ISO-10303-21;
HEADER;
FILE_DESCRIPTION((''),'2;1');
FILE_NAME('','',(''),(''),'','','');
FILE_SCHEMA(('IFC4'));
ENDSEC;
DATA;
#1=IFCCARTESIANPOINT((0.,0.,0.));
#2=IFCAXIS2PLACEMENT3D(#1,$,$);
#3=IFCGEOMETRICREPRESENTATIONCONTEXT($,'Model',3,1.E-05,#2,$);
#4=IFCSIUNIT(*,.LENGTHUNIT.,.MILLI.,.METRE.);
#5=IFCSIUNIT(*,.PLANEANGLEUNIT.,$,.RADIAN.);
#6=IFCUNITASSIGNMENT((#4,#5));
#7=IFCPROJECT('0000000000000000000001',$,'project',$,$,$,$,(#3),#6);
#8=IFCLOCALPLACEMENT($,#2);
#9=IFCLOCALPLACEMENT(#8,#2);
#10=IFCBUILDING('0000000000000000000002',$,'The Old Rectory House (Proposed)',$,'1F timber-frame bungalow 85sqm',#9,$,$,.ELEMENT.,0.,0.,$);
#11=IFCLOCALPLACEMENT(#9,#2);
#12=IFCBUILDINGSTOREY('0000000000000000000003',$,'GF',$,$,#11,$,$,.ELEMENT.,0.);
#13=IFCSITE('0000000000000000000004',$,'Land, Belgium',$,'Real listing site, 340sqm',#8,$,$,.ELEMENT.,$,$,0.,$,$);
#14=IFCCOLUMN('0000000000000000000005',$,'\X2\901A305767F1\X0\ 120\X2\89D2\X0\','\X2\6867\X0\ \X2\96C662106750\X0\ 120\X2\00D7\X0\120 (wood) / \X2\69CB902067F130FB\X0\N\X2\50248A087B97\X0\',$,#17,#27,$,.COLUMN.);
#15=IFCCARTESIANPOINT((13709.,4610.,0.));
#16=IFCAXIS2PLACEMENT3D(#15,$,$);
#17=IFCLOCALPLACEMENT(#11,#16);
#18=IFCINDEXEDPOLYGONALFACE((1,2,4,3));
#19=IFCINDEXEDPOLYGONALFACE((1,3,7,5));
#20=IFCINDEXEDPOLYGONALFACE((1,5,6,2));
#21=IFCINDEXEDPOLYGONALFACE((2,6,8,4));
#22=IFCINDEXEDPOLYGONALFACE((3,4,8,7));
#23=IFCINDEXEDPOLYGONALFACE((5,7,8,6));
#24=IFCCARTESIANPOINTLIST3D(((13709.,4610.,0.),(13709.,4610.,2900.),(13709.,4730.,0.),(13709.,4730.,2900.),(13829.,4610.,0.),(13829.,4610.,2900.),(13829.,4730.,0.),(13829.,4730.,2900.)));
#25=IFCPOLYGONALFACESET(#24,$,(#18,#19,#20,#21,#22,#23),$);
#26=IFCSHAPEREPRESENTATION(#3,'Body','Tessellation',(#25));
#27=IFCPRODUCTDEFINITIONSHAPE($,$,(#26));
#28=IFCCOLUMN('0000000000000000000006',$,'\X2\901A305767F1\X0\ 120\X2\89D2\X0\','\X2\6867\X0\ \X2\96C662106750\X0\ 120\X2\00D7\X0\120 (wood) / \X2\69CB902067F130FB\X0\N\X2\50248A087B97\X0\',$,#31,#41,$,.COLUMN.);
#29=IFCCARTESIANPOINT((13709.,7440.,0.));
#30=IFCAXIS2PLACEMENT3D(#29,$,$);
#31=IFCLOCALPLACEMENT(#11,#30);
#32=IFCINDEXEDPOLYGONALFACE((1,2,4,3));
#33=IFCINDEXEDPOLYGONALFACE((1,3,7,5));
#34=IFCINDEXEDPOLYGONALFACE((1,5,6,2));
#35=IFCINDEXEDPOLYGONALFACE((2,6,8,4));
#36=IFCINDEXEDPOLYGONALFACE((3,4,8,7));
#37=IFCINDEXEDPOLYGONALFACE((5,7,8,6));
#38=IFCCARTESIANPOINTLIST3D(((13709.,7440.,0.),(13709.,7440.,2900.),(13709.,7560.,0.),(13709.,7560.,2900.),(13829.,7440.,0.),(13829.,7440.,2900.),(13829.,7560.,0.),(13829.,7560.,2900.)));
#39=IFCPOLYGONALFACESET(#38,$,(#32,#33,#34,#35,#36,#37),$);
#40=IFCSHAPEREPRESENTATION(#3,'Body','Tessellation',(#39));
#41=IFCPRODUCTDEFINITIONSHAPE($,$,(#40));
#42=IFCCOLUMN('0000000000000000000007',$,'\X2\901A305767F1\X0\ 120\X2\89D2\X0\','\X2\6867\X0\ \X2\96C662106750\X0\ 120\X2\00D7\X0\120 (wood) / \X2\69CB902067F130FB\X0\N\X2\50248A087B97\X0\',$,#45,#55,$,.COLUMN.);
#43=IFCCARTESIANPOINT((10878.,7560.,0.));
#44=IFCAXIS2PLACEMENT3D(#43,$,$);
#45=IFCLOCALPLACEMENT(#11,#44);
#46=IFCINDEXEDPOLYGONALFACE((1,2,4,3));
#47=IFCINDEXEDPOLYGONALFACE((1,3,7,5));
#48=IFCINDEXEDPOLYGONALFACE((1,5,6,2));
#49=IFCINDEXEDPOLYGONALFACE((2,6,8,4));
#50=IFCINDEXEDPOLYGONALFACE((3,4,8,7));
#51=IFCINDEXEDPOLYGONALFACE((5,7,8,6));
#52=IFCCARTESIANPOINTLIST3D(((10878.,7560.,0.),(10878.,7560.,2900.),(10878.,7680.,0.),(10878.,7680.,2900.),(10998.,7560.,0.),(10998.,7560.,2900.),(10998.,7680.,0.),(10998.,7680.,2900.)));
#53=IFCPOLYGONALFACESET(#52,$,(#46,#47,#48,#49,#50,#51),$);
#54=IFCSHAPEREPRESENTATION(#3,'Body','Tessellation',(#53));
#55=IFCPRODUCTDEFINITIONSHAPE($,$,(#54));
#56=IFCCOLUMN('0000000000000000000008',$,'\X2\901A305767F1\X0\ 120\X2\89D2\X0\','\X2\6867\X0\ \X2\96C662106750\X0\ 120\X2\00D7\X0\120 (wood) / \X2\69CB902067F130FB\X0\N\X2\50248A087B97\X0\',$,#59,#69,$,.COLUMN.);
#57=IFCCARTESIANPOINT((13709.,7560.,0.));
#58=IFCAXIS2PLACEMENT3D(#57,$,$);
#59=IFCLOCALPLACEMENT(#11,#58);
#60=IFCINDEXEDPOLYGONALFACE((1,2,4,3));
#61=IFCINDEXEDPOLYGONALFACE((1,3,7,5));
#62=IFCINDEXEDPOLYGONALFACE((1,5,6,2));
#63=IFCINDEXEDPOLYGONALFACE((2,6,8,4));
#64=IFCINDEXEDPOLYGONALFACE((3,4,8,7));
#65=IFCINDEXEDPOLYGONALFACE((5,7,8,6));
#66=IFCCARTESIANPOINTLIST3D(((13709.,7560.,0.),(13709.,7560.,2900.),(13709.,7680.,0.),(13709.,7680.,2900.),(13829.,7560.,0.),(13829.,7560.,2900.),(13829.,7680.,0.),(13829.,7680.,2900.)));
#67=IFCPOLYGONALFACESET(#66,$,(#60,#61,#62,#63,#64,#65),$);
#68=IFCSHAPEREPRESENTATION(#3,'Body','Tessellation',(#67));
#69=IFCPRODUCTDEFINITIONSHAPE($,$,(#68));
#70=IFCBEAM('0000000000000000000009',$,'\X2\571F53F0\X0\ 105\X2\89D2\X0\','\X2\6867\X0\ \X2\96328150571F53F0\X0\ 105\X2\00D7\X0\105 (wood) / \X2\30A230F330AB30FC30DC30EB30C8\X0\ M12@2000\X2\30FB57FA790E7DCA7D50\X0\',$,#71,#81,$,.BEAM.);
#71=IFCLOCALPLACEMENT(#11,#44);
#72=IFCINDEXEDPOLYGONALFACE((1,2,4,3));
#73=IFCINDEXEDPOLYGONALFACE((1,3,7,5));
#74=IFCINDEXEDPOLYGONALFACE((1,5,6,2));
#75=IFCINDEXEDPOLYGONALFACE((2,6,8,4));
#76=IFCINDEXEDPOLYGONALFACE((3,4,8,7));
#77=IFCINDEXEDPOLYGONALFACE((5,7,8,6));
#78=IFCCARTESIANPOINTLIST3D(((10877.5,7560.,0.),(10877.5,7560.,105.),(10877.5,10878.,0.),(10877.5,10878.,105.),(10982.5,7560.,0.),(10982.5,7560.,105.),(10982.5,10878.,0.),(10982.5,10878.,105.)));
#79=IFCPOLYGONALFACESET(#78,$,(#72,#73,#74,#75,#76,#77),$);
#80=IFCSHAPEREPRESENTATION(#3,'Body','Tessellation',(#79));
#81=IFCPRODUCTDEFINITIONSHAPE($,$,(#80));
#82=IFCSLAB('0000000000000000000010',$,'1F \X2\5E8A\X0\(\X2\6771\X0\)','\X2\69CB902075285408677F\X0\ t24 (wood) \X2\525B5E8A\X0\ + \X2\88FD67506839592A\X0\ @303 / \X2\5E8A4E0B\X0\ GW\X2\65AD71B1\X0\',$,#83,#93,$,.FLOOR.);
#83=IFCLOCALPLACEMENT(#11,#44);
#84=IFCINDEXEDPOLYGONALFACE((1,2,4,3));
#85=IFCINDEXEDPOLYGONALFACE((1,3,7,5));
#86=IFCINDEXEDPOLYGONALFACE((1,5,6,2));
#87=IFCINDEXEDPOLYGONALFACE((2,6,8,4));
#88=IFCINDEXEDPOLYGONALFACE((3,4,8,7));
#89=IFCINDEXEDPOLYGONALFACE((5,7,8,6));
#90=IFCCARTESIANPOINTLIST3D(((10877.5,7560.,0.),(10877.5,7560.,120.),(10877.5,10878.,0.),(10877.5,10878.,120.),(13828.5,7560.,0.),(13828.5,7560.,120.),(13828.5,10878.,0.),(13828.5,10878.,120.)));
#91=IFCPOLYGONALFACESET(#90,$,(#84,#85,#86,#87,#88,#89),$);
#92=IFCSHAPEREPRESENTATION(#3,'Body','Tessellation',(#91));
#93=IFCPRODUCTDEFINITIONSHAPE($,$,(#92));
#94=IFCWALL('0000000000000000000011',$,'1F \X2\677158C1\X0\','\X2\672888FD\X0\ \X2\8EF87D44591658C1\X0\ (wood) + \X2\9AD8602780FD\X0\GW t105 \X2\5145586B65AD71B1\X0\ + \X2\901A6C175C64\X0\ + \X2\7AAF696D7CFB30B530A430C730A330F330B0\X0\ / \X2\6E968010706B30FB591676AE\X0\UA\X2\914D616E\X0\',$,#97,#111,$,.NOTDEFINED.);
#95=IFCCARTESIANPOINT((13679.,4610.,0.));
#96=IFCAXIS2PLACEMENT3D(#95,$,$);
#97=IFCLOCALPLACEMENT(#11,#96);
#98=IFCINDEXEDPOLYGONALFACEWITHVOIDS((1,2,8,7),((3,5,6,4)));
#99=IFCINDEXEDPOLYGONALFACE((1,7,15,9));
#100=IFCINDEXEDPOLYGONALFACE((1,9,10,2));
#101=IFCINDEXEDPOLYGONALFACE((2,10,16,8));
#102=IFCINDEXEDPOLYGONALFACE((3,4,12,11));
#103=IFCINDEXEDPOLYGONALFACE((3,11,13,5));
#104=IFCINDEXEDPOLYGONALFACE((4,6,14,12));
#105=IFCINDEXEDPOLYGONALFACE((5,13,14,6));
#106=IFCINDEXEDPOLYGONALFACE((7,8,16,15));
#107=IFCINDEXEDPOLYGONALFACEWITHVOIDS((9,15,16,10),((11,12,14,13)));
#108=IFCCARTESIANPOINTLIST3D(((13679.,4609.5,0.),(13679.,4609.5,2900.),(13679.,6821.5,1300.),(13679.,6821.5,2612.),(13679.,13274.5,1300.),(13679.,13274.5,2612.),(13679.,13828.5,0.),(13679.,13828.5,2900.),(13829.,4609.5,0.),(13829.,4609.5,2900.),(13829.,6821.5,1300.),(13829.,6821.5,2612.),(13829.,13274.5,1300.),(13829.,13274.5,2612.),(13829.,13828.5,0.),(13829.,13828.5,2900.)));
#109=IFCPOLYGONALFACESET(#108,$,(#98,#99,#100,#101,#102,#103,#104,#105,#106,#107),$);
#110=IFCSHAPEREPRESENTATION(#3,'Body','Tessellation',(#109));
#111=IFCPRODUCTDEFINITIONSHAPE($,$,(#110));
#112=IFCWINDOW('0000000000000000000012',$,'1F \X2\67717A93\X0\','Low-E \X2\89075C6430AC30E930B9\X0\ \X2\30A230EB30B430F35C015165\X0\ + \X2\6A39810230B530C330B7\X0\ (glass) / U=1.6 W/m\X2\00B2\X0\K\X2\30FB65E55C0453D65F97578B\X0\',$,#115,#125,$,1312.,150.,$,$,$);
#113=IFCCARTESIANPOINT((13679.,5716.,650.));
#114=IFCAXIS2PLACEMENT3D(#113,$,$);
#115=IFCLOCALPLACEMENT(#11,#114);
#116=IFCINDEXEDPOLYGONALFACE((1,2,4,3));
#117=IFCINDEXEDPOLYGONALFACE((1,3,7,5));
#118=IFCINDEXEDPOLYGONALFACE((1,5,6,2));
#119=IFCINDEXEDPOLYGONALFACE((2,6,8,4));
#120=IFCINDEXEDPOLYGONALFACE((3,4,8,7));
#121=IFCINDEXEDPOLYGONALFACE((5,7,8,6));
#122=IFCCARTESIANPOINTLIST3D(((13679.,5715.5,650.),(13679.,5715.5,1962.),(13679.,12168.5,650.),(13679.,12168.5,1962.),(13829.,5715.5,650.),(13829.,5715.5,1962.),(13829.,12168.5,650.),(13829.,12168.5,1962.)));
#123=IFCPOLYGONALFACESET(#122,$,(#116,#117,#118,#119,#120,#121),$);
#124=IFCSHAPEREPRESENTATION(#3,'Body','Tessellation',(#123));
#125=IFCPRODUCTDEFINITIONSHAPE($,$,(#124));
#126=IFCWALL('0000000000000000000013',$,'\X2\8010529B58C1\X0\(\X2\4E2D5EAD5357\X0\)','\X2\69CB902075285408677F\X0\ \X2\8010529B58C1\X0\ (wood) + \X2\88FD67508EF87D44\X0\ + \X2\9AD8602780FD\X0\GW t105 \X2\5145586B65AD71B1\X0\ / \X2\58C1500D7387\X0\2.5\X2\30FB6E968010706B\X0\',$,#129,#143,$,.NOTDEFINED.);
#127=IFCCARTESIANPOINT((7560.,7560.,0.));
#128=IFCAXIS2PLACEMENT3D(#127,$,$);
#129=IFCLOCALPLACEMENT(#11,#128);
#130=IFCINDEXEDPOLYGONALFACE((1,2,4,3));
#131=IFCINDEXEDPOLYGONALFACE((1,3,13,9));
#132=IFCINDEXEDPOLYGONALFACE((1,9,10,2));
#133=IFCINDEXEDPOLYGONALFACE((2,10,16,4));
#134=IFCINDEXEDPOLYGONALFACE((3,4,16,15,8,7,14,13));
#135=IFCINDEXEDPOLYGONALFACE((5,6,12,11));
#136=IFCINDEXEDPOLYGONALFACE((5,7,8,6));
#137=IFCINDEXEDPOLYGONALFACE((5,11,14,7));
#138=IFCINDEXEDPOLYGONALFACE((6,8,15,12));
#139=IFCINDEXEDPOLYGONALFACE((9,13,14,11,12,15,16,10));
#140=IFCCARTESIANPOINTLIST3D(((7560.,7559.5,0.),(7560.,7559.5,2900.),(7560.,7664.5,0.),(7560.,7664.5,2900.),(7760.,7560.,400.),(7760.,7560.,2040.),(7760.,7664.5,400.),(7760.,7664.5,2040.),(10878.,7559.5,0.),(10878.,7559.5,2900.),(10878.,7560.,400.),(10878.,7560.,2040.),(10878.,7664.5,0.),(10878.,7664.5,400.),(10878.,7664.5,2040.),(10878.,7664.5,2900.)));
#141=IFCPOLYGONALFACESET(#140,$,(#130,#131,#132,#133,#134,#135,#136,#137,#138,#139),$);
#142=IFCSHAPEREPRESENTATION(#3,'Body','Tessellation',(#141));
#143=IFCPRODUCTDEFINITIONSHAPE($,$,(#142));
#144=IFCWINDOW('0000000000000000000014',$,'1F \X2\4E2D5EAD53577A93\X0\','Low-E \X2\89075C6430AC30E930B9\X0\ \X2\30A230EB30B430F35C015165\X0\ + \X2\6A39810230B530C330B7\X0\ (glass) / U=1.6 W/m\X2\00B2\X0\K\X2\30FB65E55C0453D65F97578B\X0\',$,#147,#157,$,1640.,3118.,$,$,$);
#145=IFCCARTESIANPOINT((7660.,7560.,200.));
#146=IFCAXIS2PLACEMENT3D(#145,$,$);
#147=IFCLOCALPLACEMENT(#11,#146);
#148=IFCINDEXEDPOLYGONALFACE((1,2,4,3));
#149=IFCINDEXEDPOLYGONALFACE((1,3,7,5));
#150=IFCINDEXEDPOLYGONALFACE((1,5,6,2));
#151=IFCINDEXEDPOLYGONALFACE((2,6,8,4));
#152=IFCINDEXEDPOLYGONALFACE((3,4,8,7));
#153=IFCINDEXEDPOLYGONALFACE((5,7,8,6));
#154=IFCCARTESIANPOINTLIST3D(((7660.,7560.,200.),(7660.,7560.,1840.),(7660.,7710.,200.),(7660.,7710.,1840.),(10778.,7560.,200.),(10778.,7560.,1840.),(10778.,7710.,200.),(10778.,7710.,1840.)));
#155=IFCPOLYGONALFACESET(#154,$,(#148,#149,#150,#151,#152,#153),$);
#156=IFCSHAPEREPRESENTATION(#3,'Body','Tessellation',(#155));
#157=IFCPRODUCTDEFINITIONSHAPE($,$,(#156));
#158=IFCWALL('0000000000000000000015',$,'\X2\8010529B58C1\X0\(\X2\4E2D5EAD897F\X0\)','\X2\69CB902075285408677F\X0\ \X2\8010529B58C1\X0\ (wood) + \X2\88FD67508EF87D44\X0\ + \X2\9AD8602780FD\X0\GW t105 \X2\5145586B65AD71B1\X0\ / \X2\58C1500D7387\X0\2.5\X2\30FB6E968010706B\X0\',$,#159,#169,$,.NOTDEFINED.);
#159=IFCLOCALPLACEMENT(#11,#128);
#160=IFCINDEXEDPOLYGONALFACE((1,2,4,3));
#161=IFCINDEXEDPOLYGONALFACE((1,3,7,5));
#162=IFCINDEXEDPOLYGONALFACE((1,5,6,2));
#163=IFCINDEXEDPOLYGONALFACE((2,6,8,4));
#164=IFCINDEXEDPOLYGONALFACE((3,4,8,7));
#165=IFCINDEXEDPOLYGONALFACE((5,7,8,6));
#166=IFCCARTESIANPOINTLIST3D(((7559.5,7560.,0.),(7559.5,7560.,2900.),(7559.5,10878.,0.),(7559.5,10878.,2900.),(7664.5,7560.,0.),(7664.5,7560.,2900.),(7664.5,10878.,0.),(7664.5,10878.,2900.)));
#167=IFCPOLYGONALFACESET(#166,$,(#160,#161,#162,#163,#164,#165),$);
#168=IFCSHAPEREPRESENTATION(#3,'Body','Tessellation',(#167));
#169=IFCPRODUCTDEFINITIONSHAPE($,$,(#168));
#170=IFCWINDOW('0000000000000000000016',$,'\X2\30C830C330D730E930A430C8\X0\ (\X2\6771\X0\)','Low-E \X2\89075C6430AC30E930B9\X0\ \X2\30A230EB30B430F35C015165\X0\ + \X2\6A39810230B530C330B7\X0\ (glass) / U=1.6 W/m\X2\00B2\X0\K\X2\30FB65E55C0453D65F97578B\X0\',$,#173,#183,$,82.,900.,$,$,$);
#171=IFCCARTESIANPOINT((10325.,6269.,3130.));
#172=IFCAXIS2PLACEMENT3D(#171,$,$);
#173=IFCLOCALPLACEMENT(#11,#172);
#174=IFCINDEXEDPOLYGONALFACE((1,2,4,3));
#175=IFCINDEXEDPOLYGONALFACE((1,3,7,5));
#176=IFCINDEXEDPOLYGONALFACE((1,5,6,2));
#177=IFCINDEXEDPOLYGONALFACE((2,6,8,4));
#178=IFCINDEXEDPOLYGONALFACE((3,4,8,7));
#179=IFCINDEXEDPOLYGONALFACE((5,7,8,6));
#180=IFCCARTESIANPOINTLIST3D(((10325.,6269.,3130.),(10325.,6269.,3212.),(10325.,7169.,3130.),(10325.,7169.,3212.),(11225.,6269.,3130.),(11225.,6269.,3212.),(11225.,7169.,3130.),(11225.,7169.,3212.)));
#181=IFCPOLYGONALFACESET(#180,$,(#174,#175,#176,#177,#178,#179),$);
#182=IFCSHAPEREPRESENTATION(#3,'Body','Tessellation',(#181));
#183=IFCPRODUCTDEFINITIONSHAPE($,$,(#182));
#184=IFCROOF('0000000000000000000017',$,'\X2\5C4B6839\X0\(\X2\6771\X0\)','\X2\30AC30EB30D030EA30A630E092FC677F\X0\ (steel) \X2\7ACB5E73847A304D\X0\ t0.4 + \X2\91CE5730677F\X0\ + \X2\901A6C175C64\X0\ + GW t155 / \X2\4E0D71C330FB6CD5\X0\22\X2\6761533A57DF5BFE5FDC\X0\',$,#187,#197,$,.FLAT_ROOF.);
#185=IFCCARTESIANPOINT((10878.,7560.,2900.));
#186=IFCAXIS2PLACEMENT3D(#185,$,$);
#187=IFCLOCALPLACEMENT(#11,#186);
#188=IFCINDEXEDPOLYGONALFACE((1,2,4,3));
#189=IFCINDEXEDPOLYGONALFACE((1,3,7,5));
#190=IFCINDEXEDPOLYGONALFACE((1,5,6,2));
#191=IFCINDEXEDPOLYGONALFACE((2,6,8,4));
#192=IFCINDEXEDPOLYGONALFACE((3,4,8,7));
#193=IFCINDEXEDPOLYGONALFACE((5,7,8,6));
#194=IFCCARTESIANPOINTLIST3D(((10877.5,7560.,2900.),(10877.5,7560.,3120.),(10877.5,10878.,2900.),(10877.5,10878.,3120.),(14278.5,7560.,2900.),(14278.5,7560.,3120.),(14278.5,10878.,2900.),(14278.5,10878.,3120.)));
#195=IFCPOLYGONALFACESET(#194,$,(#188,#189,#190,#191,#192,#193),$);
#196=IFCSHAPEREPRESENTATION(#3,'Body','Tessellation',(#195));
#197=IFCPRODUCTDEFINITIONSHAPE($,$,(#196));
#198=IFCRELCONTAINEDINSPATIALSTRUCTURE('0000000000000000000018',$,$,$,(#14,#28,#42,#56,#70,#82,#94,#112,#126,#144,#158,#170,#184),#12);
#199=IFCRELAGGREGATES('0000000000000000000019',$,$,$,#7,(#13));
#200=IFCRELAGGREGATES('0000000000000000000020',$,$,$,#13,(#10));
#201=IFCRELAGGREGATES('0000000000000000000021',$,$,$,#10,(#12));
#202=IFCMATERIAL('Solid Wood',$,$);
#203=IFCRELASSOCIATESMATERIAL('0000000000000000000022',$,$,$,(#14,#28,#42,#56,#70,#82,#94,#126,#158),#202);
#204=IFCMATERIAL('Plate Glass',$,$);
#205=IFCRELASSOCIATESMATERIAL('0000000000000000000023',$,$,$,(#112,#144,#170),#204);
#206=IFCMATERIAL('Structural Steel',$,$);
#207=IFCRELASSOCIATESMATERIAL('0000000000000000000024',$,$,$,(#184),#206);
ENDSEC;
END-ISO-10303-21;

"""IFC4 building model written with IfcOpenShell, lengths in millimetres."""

from ifc_helpers import new_model, si_unit, frame, frame_2d, origin, place, context, project, spatial, rectangle, extrude, material, element, fill, save


model = new_model("IFC4")

# Units and contexts
model_context = context("Model", 3, precision=1e-05, world=origin())
ifc_project = project(units=[si_unit("LENGTHUNIT", "METRE", prefix="MILLI"), si_unit("PLANEANGLEUNIT", "RADIAN")], contexts=[model_context])

# Site, building, storey
site_placement = place(None, origin())
site = spatial("IfcSite", under=ifc_project, at=site_placement, Name="Land, Belgium", ObjectType="Real listing site, 340sqm", CompositionType="ELEMENT", RefElevation=0.0)
building_placement = place(site_placement, origin())
building = spatial("IfcBuilding", under=site, at=building_placement, Name="The Old Rectory House (Proposed)", ObjectType="1F timber-frame bungalow 85sqm", CompositionType="ELEMENT", ElevationOfRefHeight=0.0, ElevationOfTerrain=0.0)
storey_placement = place(building_placement, origin())
storey = spatial("IfcBuildingStorey", under=building, at=storey_placement, Name="GF", CompositionType="ELEMENT", Elevation=0.0)

# Columns
ifc_material_1 = material(Name="Solid Wood")
column_1_placement = place(storey_placement, frame((13709.0, 4610.0, 0.0)))
element("IfcColumn", 1, at=column_1_placement, inside=storey, material=ifc_material_1, Name="通し柱 120角", Description="桧 集成材 120×120 (wood) / 構造柱・N値計算", PredefinedType="COLUMN", context=model_context, shape_type="SweptSolid", body=[
    extrude(rectangle(XDim=120.0, YDim=120.0, at=frame_2d((60.0, 60.0))), frame((13709.0, 4610.0, 0.0)), (0.0, 0.0, 1.0), 2900.0),
])
column_2_placement = place(storey_placement, frame((13709.0, 7440.0, 0.0)))
element("IfcColumn", 2, at=column_2_placement, inside=storey, material=ifc_material_1, Name="通し柱 120角", Description="桧 集成材 120×120 (wood) / 構造柱・N値計算", PredefinedType="COLUMN", context=model_context, shape_type="SweptSolid", body=[
    extrude(rectangle(XDim=120.0, YDim=120.0, at=frame_2d((60.0, 60.0))), frame((13709.0, 7440.0, 0.0)), (0.0, 0.0, 1.0), 2900.0),
])
column_3_placement = place(storey_placement, frame((10878.0, 7560.0, 0.0)))
element("IfcColumn", 3, at=column_3_placement, inside=storey, material=ifc_material_1, Name="通し柱 120角", Description="桧 集成材 120×120 (wood) / 構造柱・N値計算", PredefinedType="COLUMN", context=model_context, shape_type="SweptSolid", body=[
    extrude(rectangle(XDim=120.0, YDim=120.0, at=frame_2d((60.0, 60.0))), frame((10878.0, 7560.0, 0.0)), (0.0, 0.0, 1.0), 2900.0),
])
column_4_placement = place(storey_placement, frame((13709.0, 7560.0, 0.0)))
element("IfcColumn", 4, at=column_4_placement, inside=storey, material=ifc_material_1, Name="通し柱 120角", Description="桧 集成材 120×120 (wood) / 構造柱・N値計算", PredefinedType="COLUMN", context=model_context, shape_type="SweptSolid", body=[
    extrude(rectangle(XDim=120.0, YDim=120.0, at=frame_2d((60.0, 60.0))), frame((13709.0, 7560.0, 0.0)), (0.0, 0.0, 1.0), 2900.0),
])

# Beam
beam_1_placement = place(storey_placement, frame((10878.0, 7560.0, 0.0)))
element("IfcBeam", 5, at=beam_1_placement, inside=storey, material=ifc_material_1, Name="土台 105角", Description="桧 防腐土台 105×105 (wood) / アンカーボルト M12@2000・基礎緊結", PredefinedType="BEAM", context=model_context, shape_type="SweptSolid", body=[
    extrude(rectangle(XDim=105.0, YDim=3318.0, at=frame_2d((52.0, 1659.0))), frame((10878.0, 7560.0, 0.0)), (0.0, 0.0, 1.0), 105.0),
])

# Slab
slab_placement = place(storey_placement, frame((10878.0, 7560.0, 0.0)))
element("IfcSlab", 6, at=slab_placement, inside=storey, material=ifc_material_1, Name="1F 床(東)", Description="構造用合板 t24 (wood) 剛床 + 製材根太 @303 / 床下 GW断熱", PredefinedType="FLOOR", context=model_context, shape_type="SweptSolid", body=[
    extrude(rectangle(XDim=2951.0, YDim=3318.0, at=frame_2d((1475.0, 1659.0))), frame((10878.0, 7560.0, 0.0)), (0.0, 0.0, 1.0), 120.0),
])

# Walls, openings, windows
wall_1_placement = place(storey_placement, frame((13679.0, 4610.0, 0.0)))
wall_1 = element("IfcWall", 7, at=wall_1_placement, inside=storey, material=ifc_material_1, Name="1F 東壁", Description="木製 軸組外壁 (wood) + 高性能GW t105 充填断熱 + 通気層 + 窯業系サイディング / 準耐火・外皮UA配慮", PredefinedType="NOTDEFINED", context=model_context, shape_type="SweptSolid", body=[
    extrude(rectangle(XDim=150.0, YDim=9219.0, at=frame_2d((75.0, 4609.0))), frame((13679.0, 4610.0, 0.0)), (0.0, 0.0, 1.0), 2900.0),
])
opening_1_placement = place(storey_placement, frame((13679.0, 5716.0, 650.0)))
opening_1 = element("IfcOpeningElement", 8, at=opening_1_placement, cuts=wall_1, PredefinedType="NOTDEFINED", context=model_context, shape_type="SweptSolid", body=[
    extrude(rectangle(XDim=150.0, YDim=6453.0, at=frame_2d((75.0, 3226.0))), frame((13679.0, 5716.0, 650.0)), (0.0, 0.0, 1.0), 1312.0),
])
ifc_material_2 = material(Name="Plate Glass")
window_1_placement = place(storey_placement, frame((13679.0, 5716.0, 650.0)))
window_1 = element("IfcWindow", 9, at=window_1_placement, inside=storey, material=ifc_material_2, Name="1F 東窓", Description="Low-E 複層ガラス アルゴン封入 + 樹脂サッシ (glass) / U=1.6 W/m²K・日射取得型", OverallHeight=1312.0, OverallWidth=150.0, context=model_context, shape_type="SweptSolid", body=[
    extrude(rectangle(XDim=150.0, YDim=6453.0, at=frame_2d((75.0, 3226.0))), frame((13679.0, 5716.0, 650.0)), (0.0, 0.0, 1.0), 1312.0),
])
fill(opening_1, window_1)
wall_2_placement = place(storey_placement, frame((7560.0, 7560.0, 0.0)))
wall_2 = element("IfcWall", 10, at=wall_2_placement, inside=storey, material=ifc_material_1, Name="耐力壁(中庭南)", Description="構造用合板 耐力壁 (wood) + 製材軸組 + 高性能GW t105 充填断熱 / 壁倍率2.5・準耐火", PredefinedType="NOTDEFINED", context=model_context, shape_type="SweptSolid", body=[
    extrude(rectangle(XDim=3318.0, YDim=105.0, at=frame_2d((1659.0, 52.0))), frame((7560.0, 7560.0, 0.0)), (0.0, 0.0, 1.0), 2900.0),
])
opening_2_placement = place(storey_placement, frame((7660.0, 7560.0, 200.0)))
opening_2 = element("IfcOpeningElement", 11, at=opening_2_placement, cuts=wall_2, PredefinedType="NOTDEFINED", context=model_context, shape_type="SweptSolid", body=[
    extrude(rectangle(XDim=3118.0, YDim=150.0, at=frame_2d((1559.0, 75.0))), frame((7660.0, 7560.0, 200.0)), (0.0, 0.0, 1.0), 1640.0),
])
window_2_placement = place(storey_placement, frame((7660.0, 7560.0, 200.0)))
window_2 = element("IfcWindow", 12, at=window_2_placement, inside=storey, material=ifc_material_2, Name="1F 中庭南窓", Description="Low-E 複層ガラス アルゴン封入 + 樹脂サッシ (glass) / U=1.6 W/m²K・日射取得型", OverallHeight=1640.0, OverallWidth=3118.0, context=model_context, shape_type="SweptSolid", body=[
    extrude(rectangle(XDim=3118.0, YDim=150.0, at=frame_2d((1559.0, 75.0))), frame((7660.0, 7560.0, 200.0)), (0.0, 0.0, 1.0), 1640.0),
])
fill(opening_2, window_2)

# Wall
wall_3_placement = place(storey_placement, frame((7560.0, 7560.0, 0.0)))
element("IfcWall", 13, at=wall_3_placement, inside=storey, material=ifc_material_1, Name="耐力壁(中庭西)", Description="構造用合板 耐力壁 (wood) + 製材軸組 + 高性能GW t105 充填断熱 / 壁倍率2.5・準耐火", PredefinedType="NOTDEFINED", context=model_context, shape_type="SweptSolid", body=[
    extrude(rectangle(XDim=105.0, YDim=3318.0, at=frame_2d((52.0, 1659.0))), frame((7560.0, 7560.0, 0.0)), (0.0, 0.0, 1.0), 2900.0),
])

# Window
window_3_placement = place(storey_placement, frame((10325.0, 6269.0, 3130.0)))
element("IfcWindow", 14, at=window_3_placement, inside=storey, material=ifc_material_2, Name="トップライト (東)", Description="Low-E 複層ガラス アルゴン封入 + 樹脂サッシ (glass) / U=1.6 W/m²K・日射取得型", OverallHeight=82.0, OverallWidth=900.0, context=model_context, shape_type="SweptSolid", body=[
    extrude(rectangle(XDim=900.0, YDim=900.0, at=frame_2d((450.0, 450.0))), frame((10325.0, 6269.0, 3130.0)), (0.0, 0.0, 1.0), 82.0),
])

# Roof
ifc_material_3 = material(Name="Structural Steel")
roof_placement = place(storey_placement, frame((10878.0, 7560.0, 2900.0)))
element("IfcRoof", 15, at=roof_placement, inside=storey, material=ifc_material_3, Name="屋根(東)", Description="ガルバリウム鋼板 (steel) 立平葺き t0.4 + 野地板 + 通気層 + GW t155 / 不燃・法22条区域対応", PredefinedType="FLAT_ROOF", context=model_context, shape_type="SweptSolid", body=[
    extrude(rectangle(XDim=3401.0, YDim=3318.0, at=frame_2d((1700.0, 1659.0))), frame((10878.0, 7560.0, 2900.0)), (0.0, 0.0, 1.0), 220.0),
])

save(model, "model.ifc")
